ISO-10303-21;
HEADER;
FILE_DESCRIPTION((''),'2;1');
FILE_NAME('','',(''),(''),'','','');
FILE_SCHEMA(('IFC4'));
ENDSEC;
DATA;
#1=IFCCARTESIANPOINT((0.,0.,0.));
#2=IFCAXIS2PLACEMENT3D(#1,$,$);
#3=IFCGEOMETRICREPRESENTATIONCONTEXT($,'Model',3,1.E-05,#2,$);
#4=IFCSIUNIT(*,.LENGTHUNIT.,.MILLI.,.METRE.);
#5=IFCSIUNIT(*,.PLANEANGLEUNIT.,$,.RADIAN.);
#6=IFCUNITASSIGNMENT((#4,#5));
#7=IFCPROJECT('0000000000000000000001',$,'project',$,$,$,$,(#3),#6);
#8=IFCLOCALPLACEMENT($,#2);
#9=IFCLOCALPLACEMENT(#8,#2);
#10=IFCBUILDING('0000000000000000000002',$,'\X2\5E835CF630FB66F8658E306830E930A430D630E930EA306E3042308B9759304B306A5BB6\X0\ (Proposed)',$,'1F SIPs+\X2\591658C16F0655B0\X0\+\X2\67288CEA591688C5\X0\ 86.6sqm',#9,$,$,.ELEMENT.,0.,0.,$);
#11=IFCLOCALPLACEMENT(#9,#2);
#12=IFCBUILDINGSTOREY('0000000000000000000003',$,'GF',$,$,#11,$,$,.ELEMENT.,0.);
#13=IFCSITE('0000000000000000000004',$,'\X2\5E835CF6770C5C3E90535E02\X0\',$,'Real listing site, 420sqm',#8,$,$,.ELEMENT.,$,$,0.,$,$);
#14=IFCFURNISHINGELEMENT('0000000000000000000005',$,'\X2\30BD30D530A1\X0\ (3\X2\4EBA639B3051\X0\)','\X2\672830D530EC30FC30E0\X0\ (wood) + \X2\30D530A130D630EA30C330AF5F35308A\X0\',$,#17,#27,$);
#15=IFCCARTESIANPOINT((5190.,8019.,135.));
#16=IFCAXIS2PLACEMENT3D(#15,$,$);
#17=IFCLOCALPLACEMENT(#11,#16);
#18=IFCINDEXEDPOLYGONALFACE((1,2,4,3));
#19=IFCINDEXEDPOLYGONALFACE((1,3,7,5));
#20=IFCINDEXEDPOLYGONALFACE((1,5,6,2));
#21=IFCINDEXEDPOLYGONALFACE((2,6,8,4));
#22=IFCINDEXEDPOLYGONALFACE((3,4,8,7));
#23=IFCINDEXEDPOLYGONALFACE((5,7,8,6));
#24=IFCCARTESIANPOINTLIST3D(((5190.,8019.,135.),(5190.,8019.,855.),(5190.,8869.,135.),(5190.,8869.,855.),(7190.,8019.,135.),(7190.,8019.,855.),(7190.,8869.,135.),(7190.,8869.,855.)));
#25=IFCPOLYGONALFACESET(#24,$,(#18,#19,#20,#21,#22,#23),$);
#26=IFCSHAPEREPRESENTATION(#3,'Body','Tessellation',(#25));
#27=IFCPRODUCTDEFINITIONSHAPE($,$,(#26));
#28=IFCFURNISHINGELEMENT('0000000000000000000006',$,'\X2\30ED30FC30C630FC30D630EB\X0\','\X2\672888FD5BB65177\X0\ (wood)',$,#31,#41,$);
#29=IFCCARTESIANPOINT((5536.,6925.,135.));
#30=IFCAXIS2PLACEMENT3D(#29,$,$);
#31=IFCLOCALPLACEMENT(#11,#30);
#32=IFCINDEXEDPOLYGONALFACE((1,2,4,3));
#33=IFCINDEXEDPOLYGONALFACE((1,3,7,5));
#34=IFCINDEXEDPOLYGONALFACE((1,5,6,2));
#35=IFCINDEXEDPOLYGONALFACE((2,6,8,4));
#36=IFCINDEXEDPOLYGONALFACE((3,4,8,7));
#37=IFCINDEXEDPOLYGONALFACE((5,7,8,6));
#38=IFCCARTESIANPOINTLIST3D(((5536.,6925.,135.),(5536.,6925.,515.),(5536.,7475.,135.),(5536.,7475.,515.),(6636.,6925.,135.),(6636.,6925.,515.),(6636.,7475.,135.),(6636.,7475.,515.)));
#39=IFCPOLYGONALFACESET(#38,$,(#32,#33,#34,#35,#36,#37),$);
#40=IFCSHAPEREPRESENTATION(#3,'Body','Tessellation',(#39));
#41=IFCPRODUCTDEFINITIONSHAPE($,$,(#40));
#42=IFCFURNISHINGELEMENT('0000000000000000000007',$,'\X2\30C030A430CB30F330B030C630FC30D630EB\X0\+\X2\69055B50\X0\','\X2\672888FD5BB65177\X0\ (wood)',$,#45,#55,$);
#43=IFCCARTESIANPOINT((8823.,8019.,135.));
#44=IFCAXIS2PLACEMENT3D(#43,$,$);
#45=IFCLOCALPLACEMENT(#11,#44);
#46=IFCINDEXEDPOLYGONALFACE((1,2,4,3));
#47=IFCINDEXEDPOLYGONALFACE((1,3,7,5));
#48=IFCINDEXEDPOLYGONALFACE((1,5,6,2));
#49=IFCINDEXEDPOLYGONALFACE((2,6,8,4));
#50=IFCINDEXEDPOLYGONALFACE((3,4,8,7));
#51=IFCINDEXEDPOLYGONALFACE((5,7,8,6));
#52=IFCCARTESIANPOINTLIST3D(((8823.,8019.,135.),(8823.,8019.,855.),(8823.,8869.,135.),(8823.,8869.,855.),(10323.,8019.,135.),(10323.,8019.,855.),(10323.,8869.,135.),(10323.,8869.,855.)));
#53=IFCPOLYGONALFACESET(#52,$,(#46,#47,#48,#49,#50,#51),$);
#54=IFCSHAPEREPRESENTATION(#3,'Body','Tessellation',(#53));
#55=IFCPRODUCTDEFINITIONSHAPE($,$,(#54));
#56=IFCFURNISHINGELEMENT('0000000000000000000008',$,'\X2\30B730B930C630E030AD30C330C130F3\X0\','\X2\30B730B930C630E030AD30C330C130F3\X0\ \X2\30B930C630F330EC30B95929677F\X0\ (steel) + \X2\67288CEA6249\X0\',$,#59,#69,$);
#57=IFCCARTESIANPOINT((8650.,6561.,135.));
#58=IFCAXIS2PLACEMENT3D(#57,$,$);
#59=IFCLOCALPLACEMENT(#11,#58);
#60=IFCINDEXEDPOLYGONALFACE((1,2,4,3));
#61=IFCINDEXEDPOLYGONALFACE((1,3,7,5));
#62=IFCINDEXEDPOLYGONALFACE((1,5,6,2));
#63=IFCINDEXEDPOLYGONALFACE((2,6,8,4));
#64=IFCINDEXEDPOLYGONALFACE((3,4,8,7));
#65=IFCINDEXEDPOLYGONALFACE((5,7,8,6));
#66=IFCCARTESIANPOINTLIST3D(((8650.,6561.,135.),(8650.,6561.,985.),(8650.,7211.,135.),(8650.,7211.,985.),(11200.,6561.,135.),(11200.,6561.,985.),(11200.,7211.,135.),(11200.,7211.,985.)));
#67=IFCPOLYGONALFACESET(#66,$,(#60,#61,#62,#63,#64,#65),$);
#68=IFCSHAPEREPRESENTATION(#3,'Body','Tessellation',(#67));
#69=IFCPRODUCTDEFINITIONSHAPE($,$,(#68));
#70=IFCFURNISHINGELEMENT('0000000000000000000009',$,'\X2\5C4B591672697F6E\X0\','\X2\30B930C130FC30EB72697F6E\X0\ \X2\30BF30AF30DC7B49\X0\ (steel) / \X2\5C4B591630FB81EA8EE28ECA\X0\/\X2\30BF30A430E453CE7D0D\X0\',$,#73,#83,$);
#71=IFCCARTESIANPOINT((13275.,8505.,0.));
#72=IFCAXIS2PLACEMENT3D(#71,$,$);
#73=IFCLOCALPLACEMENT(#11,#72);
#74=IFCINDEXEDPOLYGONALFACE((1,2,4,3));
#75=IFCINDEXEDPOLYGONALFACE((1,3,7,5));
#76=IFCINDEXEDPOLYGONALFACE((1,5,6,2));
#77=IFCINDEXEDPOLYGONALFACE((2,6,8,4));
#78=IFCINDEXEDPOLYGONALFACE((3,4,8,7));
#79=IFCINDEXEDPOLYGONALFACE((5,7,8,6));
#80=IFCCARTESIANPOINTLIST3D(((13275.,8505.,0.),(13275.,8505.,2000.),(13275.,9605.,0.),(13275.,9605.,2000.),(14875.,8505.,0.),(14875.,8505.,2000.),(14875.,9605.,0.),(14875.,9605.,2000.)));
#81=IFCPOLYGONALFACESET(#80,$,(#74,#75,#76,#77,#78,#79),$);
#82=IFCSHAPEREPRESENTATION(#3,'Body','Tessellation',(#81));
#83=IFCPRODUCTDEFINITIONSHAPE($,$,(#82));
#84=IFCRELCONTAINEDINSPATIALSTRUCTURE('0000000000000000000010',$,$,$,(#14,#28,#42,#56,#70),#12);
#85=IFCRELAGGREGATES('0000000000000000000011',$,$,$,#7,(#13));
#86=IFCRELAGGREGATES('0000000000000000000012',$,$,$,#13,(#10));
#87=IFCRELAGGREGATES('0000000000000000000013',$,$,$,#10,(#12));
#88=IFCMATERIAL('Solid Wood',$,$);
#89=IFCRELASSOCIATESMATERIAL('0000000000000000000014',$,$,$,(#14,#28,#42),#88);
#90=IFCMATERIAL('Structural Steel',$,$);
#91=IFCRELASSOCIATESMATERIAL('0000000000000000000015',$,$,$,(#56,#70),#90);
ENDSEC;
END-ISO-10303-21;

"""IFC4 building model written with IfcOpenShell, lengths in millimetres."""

from ifc_helpers import new_model, si_unit, frame, frame_2d, origin, place, context, project, spatial, rectangle, extrude, material, element, save


model = new_model("IFC4")

# Units and contexts
model_context = context("Model", 3, precision=1e-05, world=origin())
ifc_project = project(units=[si_unit("LENGTHUNIT", "METRE", prefix="MILLI"), si_unit("PLANEANGLEUNIT", "RADIAN")], contexts=[model_context])

# Site, building, storey
site_placement = place(None, origin())
site = spatial("IfcSite", under=ifc_project, at=site_placement, Name="広島県尾道市", ObjectType="Real listing site, 420sqm", CompositionType="ELEMENT", RefElevation=0.0)
building_placement = place(site_placement, origin())
building = spatial("IfcBuilding", under=site, at=building_placement, Name="広島・書斎とライブラリのある静かな家 (Proposed)", ObjectType="1F SIPs+外壁漆喰+木質外装 86.6sqm", CompositionType="ELEMENT", ElevationOfRefHeight=0.0, ElevationOfTerrain=0.0)
storey_placement = place(building_placement, origin())
storey = spatial("IfcBuildingStorey", under=building, at=storey_placement, Name="GF", CompositionType="ELEMENT", Elevation=0.0)

# Shared definitions
ifc_material_1 = material(Name="Solid Wood")

# Shared definitions
ifc_material_2 = material(Name="Structural Steel")

# Furnishing elements
furnishing_1_placement = place(storey_placement, frame((5190.0, 8019.0, 135.0)))
element("IfcFurnishingElement", 1, at=furnishing_1_placement, inside=storey, material=ifc_material_1, Name="ソファ (3人掛け)", Description="木フレーム (wood) + ファブリック張り", context=model_context, shape_type="SweptSolid", body=[
    extrude(rectangle(XDim=2000.0, YDim=850.0, at=frame_2d((1000.0, 425.0))), frame((5190.0, 8019.0, 135.0)), (0.0, 0.0, 1.0), 720.0),
])
furnishing_2_placement = place(storey_placement, frame((5536.0, 6925.0, 135.0)))
element("IfcFurnishingElement", 2, at=furnishing_2_placement, inside=storey, material=ifc_material_1, Name="ローテーブル", Description="木製家具 (wood)", context=model_context, shape_type="SweptSolid", body=[
    extrude(rectangle(XDim=1100.0, YDim=550.0, at=frame_2d((550.0, 275.0))), frame((5536.0, 6925.0, 135.0)), (0.0, 0.0, 1.0), 380.0),
])
furnishing_3_placement = place(storey_placement, frame((8823.0, 8019.0, 135.0)))
element("IfcFurnishingElement", 3, at=furnishing_3_placement, inside=storey, material=ifc_material_1, Name="ダイニングテーブル+椅子", Description="木製家具 (wood)", context=model_context, shape_type="SweptSolid", body=[
    extrude(rectangle(XDim=1500.0, YDim=850.0, at=frame_2d((750.0, 425.0))), frame((8823.0, 8019.0, 135.0)), (0.0, 0.0, 1.0), 720.0),
])
furnishing_4_placement = place(storey_placement, frame((8650.0, 6561.0, 135.0)))
element("IfcFurnishingElement", 4, at=furnishing_4_placement, inside=storey, material=ifc_material_2, Name="システムキッチン", Description="システムキッチン ステンレス天板 (steel) + 木質扉", context=model_context, shape_type="SweptSolid", body=[
    extrude(rectangle(XDim=2550.0, YDim=650.0, at=frame_2d((1275.0, 325.0))), frame((8650.0, 6561.0, 135.0)), (0.0, 0.0, 1.0), 850.0),
])
furnishing_5_placement = place(storey_placement, frame((13275.0, 8505.0, 0.0)))
element("IfcFurnishingElement", 5, at=furnishing_5_placement, inside=storey, material=ifc_material_2, Name="屋外物置", Description="スチール物置 タクボ等 (steel) / 屋外・自転車/タイヤ収納", context=model_context, shape_type="SweptSolid", body=[
    extrude(rectangle(XDim=1600.0, YDim=1100.0, at=frame_2d((800.0, 550.0))), frame((13275.0, 8505.0, 0.0)), (0.0, 0.0, 1.0), 2000.0),
])

save(model, "model.ifc")
